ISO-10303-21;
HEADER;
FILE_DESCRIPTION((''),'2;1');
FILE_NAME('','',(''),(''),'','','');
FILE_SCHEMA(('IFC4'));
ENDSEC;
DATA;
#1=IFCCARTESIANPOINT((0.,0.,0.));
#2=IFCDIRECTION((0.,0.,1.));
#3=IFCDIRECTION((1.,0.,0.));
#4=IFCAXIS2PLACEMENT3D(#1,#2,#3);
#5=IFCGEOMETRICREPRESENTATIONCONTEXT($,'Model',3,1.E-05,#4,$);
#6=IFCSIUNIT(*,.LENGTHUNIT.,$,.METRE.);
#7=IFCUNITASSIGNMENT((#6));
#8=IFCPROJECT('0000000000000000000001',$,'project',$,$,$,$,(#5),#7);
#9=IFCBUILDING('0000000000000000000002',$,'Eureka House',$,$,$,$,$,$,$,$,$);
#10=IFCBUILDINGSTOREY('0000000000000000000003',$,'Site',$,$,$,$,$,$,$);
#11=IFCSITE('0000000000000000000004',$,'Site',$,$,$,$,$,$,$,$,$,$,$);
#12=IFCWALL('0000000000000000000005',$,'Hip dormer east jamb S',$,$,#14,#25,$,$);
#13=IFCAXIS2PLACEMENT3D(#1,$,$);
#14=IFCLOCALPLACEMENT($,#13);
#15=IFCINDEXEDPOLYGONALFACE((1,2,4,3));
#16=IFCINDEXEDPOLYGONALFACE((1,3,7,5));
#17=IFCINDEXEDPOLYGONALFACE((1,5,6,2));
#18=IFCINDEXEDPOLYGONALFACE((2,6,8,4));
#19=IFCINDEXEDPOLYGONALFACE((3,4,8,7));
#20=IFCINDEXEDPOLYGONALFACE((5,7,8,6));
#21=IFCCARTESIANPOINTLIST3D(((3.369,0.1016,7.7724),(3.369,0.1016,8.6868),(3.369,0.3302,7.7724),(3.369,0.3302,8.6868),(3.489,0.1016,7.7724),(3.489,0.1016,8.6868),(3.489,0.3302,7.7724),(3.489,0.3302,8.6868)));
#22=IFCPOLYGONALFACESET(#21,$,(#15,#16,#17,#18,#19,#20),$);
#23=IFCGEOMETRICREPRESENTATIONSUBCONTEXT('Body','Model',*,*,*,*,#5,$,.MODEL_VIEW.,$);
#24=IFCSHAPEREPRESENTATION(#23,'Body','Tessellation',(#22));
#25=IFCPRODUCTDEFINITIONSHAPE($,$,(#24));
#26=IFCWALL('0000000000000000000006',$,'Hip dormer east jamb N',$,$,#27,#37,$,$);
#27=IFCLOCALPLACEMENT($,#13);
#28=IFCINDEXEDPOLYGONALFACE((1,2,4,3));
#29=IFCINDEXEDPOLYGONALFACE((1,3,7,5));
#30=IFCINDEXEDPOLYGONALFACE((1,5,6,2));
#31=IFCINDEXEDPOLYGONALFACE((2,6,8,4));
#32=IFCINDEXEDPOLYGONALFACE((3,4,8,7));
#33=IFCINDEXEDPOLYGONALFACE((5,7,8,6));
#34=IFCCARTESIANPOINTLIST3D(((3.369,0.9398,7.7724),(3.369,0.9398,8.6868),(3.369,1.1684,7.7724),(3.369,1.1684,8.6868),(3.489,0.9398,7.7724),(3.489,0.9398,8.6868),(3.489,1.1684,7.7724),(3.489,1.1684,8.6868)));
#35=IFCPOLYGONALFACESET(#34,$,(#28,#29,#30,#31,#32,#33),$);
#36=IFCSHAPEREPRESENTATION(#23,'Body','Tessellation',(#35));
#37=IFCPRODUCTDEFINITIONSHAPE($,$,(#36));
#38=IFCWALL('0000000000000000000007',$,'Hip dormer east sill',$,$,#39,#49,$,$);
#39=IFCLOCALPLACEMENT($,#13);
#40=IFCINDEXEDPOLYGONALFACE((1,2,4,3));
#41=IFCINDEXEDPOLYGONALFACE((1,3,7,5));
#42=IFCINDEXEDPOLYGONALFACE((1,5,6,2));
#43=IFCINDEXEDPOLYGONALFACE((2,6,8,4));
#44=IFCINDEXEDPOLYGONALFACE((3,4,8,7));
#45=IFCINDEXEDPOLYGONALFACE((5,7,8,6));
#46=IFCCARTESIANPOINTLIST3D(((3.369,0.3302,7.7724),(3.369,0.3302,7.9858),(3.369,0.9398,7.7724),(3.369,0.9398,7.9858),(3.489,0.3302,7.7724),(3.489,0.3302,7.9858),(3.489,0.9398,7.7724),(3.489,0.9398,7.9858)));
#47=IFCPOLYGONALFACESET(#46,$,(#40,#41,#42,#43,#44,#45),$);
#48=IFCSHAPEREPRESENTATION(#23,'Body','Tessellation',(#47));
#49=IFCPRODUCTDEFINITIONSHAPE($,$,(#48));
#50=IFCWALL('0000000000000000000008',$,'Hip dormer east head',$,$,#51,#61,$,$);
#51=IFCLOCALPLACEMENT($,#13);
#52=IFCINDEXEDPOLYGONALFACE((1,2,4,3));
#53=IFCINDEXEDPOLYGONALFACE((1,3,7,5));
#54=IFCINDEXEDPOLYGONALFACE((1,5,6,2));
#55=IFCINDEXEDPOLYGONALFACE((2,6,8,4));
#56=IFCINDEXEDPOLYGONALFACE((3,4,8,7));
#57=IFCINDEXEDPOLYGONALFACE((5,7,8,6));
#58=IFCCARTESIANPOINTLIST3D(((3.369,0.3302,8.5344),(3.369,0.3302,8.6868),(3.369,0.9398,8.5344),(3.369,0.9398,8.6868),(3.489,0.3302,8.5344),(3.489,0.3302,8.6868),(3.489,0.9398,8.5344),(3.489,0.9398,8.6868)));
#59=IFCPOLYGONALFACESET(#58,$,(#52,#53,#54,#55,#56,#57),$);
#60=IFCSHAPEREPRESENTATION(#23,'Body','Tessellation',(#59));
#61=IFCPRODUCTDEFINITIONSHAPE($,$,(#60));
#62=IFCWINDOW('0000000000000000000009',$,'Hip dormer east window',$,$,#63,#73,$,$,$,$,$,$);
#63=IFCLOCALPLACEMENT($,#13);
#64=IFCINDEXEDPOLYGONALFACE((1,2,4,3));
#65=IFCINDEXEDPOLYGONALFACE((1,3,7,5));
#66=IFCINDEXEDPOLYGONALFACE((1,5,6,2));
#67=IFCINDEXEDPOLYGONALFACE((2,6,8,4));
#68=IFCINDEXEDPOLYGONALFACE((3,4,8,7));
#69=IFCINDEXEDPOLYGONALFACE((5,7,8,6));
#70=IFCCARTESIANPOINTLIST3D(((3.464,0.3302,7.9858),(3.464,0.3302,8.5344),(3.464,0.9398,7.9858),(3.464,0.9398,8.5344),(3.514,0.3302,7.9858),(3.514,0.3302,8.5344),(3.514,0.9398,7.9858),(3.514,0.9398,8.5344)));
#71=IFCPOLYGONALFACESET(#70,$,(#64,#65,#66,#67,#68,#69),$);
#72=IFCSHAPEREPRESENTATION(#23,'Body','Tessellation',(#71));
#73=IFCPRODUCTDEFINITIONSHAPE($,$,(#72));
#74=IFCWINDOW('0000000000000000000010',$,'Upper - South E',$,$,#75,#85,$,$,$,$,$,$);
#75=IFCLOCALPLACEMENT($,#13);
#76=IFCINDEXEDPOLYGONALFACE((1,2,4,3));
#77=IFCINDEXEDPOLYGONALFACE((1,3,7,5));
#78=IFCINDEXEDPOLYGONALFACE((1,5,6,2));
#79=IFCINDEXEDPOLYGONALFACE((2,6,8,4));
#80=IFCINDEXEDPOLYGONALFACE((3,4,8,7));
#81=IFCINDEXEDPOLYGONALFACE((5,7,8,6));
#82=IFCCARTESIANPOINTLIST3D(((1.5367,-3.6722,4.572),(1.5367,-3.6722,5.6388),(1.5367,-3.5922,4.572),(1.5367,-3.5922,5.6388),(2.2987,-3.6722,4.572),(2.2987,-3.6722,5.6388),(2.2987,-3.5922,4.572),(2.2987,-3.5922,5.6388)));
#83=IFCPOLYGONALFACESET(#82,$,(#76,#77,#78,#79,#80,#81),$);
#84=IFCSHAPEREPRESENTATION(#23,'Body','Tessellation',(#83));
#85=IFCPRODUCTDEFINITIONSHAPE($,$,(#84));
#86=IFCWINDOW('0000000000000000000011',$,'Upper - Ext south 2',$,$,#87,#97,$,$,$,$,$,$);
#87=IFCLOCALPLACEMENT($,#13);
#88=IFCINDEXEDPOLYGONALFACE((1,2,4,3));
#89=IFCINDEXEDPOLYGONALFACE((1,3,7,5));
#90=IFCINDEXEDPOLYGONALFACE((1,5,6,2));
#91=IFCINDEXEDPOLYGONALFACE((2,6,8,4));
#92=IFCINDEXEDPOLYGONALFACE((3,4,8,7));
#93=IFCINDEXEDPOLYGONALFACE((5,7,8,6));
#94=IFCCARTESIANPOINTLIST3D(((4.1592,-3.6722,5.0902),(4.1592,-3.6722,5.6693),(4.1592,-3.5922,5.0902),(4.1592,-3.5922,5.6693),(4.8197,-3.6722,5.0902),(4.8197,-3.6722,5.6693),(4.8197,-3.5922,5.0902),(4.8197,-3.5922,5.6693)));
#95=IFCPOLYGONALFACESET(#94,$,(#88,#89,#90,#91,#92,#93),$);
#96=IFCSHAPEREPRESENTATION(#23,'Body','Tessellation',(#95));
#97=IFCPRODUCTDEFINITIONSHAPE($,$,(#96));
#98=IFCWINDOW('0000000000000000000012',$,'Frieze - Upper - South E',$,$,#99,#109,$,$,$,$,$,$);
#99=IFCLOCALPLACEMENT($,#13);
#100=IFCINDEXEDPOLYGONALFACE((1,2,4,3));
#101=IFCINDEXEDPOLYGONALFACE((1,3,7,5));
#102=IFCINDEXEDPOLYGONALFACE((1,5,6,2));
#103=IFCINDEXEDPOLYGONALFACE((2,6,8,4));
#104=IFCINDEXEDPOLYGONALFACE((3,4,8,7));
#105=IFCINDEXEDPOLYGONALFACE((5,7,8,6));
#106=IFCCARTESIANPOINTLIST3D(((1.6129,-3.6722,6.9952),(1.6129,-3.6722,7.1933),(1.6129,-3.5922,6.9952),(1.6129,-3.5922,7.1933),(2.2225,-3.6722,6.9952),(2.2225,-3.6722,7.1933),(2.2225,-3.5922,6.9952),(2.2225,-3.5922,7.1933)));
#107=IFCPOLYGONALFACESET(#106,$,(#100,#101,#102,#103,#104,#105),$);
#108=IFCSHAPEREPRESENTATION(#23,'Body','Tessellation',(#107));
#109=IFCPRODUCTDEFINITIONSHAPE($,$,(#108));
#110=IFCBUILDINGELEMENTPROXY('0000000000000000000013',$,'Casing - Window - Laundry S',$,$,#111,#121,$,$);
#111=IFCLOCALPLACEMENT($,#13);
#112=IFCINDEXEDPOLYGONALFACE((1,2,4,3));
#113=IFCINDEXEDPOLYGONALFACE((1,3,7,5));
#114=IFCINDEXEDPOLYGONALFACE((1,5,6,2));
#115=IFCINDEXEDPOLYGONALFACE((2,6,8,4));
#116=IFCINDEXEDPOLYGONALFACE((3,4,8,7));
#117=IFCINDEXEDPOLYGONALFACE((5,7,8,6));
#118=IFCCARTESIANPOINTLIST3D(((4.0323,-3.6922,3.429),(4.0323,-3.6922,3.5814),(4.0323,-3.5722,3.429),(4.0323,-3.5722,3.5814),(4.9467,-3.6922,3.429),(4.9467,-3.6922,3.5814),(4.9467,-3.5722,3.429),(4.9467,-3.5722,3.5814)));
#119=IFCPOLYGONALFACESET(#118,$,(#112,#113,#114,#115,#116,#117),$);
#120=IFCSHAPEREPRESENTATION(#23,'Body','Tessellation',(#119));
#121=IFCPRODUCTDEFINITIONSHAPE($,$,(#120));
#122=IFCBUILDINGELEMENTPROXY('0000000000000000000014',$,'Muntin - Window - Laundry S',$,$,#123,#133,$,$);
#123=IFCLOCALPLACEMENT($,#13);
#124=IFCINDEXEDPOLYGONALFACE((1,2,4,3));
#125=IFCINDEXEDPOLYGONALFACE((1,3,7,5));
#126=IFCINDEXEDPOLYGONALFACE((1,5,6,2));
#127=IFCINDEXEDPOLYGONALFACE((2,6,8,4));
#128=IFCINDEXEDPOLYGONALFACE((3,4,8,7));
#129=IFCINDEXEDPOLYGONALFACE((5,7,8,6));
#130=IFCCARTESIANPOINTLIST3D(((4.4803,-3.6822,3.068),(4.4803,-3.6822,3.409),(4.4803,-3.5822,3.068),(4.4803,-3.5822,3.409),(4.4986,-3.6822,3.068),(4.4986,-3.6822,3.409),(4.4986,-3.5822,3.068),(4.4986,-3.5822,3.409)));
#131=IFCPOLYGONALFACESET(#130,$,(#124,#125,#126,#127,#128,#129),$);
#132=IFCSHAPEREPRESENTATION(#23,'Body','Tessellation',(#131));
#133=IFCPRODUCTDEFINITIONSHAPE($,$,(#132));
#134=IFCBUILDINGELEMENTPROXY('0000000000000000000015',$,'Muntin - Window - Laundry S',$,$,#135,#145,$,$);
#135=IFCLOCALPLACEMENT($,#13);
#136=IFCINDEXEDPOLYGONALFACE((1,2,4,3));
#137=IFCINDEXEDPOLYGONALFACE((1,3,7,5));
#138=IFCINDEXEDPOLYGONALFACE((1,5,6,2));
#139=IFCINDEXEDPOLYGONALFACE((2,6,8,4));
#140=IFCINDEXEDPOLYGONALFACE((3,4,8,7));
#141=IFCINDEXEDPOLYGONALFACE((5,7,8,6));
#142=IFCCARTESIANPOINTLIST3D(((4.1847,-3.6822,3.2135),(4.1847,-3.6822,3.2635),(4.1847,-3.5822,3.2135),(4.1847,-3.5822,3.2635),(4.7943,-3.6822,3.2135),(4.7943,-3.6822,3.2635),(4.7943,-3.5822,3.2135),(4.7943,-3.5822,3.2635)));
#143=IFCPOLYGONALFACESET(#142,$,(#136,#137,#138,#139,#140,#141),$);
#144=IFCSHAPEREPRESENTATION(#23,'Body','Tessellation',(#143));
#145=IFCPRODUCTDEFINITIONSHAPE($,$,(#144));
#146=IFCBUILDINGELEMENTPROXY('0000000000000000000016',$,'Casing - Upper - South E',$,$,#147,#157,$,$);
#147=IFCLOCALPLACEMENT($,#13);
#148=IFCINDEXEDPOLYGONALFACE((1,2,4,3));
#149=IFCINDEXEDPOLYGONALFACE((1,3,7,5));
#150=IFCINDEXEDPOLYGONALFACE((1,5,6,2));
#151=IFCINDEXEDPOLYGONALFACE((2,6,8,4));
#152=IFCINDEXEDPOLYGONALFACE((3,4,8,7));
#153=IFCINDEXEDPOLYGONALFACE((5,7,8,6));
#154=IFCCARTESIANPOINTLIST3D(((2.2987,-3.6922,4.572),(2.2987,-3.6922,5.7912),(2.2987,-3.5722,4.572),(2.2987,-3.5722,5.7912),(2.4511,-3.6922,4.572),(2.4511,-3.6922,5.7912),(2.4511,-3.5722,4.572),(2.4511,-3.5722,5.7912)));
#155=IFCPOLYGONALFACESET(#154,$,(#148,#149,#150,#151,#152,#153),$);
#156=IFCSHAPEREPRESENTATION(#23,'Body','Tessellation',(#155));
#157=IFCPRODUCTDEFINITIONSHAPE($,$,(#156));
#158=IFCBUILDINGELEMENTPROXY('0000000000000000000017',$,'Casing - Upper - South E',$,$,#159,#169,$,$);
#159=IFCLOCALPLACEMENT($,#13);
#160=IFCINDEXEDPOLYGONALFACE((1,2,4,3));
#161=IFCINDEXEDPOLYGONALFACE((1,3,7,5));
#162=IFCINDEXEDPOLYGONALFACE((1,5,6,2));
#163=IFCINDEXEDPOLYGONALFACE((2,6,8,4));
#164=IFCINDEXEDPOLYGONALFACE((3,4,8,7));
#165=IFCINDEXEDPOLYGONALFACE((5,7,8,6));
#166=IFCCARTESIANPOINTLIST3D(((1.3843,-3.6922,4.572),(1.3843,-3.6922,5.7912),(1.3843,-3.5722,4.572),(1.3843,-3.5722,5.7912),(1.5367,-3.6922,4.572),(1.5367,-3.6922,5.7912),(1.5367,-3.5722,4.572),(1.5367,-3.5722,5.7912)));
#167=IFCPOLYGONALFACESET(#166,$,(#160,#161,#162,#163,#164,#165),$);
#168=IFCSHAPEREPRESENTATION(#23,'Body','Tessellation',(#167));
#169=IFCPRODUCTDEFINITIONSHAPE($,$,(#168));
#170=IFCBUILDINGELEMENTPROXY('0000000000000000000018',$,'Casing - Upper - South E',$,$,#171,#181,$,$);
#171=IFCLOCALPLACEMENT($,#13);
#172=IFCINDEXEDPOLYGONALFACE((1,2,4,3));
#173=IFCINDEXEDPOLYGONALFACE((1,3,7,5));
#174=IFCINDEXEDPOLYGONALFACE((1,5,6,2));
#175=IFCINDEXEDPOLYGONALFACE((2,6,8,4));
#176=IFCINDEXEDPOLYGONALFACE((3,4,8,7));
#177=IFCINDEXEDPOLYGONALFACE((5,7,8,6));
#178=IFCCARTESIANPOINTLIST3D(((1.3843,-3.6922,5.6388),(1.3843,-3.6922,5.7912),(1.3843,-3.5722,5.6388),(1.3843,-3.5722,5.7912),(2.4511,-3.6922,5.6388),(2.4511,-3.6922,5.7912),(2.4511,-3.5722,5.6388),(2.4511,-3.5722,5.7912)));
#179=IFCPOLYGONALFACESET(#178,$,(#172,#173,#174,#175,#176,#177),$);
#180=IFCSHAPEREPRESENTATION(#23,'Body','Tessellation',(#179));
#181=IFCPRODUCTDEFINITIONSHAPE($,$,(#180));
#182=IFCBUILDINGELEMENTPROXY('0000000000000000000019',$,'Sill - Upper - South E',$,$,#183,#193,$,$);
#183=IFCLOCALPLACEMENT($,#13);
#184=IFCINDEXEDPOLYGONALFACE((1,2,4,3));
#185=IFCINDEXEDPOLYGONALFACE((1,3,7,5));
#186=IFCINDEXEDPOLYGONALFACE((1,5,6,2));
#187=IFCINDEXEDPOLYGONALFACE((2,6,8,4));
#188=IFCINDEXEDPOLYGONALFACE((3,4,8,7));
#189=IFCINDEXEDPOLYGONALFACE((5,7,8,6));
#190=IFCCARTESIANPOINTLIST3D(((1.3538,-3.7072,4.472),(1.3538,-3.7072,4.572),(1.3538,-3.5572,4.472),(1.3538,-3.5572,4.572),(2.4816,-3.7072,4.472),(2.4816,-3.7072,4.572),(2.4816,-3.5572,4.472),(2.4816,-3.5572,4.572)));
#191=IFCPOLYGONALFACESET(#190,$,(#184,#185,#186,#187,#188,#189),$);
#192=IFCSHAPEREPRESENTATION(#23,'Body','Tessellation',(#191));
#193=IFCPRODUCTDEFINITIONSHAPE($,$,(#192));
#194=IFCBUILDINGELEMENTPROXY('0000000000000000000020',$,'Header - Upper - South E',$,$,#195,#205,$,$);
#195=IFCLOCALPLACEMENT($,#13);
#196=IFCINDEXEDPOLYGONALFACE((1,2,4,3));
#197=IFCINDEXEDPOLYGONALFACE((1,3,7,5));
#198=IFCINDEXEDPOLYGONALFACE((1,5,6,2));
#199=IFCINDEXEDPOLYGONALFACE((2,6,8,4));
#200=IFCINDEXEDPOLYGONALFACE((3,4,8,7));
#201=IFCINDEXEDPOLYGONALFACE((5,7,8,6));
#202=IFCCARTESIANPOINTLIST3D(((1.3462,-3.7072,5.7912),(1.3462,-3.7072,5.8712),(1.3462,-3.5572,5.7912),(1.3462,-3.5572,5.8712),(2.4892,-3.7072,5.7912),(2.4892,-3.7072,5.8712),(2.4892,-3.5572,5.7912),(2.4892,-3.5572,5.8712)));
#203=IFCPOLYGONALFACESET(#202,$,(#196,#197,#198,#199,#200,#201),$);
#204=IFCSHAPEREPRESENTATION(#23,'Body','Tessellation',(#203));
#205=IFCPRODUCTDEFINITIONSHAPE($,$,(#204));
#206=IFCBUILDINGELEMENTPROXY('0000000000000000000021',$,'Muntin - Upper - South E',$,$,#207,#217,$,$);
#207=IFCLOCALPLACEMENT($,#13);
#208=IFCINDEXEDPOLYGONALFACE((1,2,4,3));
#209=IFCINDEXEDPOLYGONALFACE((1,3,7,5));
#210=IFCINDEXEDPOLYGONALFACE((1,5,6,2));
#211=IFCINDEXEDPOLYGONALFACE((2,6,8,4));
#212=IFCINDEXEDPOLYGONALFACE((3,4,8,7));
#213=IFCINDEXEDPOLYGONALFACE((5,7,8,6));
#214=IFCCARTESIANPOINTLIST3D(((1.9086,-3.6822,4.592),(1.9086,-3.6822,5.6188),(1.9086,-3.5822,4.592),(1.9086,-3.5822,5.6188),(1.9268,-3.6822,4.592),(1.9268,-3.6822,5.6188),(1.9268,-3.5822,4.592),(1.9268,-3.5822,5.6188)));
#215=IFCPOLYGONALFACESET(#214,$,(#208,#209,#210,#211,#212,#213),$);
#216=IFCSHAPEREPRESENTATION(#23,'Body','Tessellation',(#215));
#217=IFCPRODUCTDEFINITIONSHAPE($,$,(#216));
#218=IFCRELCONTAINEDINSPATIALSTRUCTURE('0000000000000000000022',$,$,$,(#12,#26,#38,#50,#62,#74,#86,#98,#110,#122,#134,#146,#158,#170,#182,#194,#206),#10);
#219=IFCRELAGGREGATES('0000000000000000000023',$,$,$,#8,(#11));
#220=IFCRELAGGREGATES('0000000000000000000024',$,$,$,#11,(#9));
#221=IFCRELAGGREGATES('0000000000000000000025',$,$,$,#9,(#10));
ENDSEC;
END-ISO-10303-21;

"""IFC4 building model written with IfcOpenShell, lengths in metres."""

from ifc_helpers import new_model, si_unit, frame, origin, origin_with_axes, origin_2d, place, context, subcontext, project, spatial, rectangle, extrude, element, save


model = new_model("IFC4")

# Units and contexts
model_context = context("Model", 3, precision=1e-05, world=origin_with_axes())
body_context = subcontext(model_context, "Body", "Model", "MODEL_VIEW")
ifc_project = project(units=[si_unit("LENGTHUNIT", "METRE")], contexts=[model_context])

# Site, building, storey
site = spatial("IfcSite", under=ifc_project, Name="Site")
building = spatial("IfcBuilding", under=site, Name="Eureka House")
storey = spatial("IfcBuildingStorey", under=building, Name="Site")

# Walls
wall_1_placement = place(None, frame((3.429, 0.2159, 7.7724), z_axis=(0.0, 0.0, 1.0), x_axis=(1.0, 0.0, 0.0)))
element("IfcWall", 1, at=wall_1_placement, inside=storey, Name="Hip dormer east jamb S", context=body_context, shape_type="SweptSolid", body=[
    extrude(rectangle(XDim=0.12, YDim=0.2286, at=origin_2d()), origin(), (0.0, 0.0, 1.0), 0.9144),
])
wall_2_placement = place(None, frame((3.429, 1.0541, 7.7724), z_axis=(0.0, 0.0, 1.0), x_axis=(1.0, 0.0, 0.0)))
element("IfcWall", 2, at=wall_2_placement, inside=storey, Name="Hip dormer east jamb N", context=body_context, shape_type="SweptSolid", body=[
    extrude(rectangle(XDim=0.12, YDim=0.2286, at=origin_2d()), origin(), (0.0, 0.0, 1.0), 0.9144),
])
wall_3_placement = place(None, frame((3.429, 0.635, 7.7724), z_axis=(0.0, 0.0, 1.0), x_axis=(1.0, 0.0, 0.0)))
element("IfcWall", 3, at=wall_3_placement, inside=storey, Name="Hip dormer east sill", context=body_context, shape_type="SweptSolid", body=[
    extrude(rectangle(XDim=0.12, YDim=0.6096, at=origin_2d()), origin(), (0.0, 0.0, 1.0), 0.2134),
])
wall_4_placement = place(None, frame((3.429, 0.635, 8.5344), z_axis=(0.0, 0.0, 1.0), x_axis=(1.0, 0.0, 0.0)))
element("IfcWall", 4, at=wall_4_placement, inside=storey, Name="Hip dormer east head", context=body_context, shape_type="SweptSolid", body=[
    extrude(rectangle(XDim=0.12, YDim=0.6096, at=origin_2d()), origin(), (0.0, 0.0, 1.0), 0.1524),
])

# Windows
window_1_placement = place(None, frame((3.489, 0.635, 7.9858), z_axis=(0.0, 0.0, 1.0), x_axis=(1.0, 0.0, 0.0)))
element("IfcWindow", 5, at=window_1_placement, inside=storey, Name="Hip dormer east window", context=body_context, shape_type="SweptSolid", body=[
    extrude(rectangle(XDim=0.05, YDim=0.6096, at=origin_2d()), origin(), (0.0, 0.0, 1.0), 0.5486),
])
window_2_placement = place(None, frame((1.9177, -3.6322, 4.572), z_axis=(0.0, 0.0, 1.0), x_axis=(1.0, 0.0, 0.0)))
element("IfcWindow", 6, at=window_2_placement, inside=storey, Name="Upper - South E", context=body_context, shape_type="SweptSolid", body=[
    extrude(rectangle(XDim=0.762, YDim=0.08, at=origin_2d()), origin(), (0.0, 0.0, 1.0), 1.0668),
])
window_3_placement = place(None, frame((4.4894, -3.6322, 5.0902), z_axis=(0.0, 0.0, 1.0), x_axis=(1.0, 0.0, 0.0)))
element("IfcWindow", 7, at=window_3_placement, inside=storey, Name="Upper - Ext south 2", context=body_context, shape_type="SweptSolid", body=[
    extrude(rectangle(XDim=0.6605, YDim=0.08, at=origin_2d()), origin(), (0.0, 0.0, 1.0), 0.5791),
])
window_4_placement = place(None, frame((1.9177, -3.6322, 6.9952), z_axis=(0.0, 0.0, 1.0), x_axis=(1.0, 0.0, 0.0)))
element("IfcWindow", 8, at=window_4_placement, inside=storey, Name="Frieze - Upper - South E", context=body_context, shape_type="SweptSolid", body=[
    extrude(rectangle(XDim=0.6096, YDim=0.08, at=origin_2d()), origin(), (0.0, 0.0, 1.0), 0.1981),
])

# Building element proxies
proxy_1_placement = place(None, frame((4.4895, -3.6322, 3.429), z_axis=(0.0, 0.0, 1.0), x_axis=(1.0, 0.0, 0.0)))
element("IfcBuildingElementProxy", 9, at=proxy_1_placement, inside=storey, Name="Casing - Window - Laundry S", context=body_context, shape_type="SweptSolid", body=[
    extrude(rectangle(XDim=0.9144, YDim=0.12, at=origin_2d()), origin(), (0.0, 0.0, 1.0), 0.1524),
])
proxy_2_placement = place(None, frame((4.4895, -3.6322, 3.068), z_axis=(0.0, 0.0, 1.0), x_axis=(1.0, 0.0, 0.0)))
element("IfcBuildingElementProxy", 10, at=proxy_2_placement, inside=storey, Name="Muntin - Window - Laundry S", context=body_context, shape_type="SweptSolid", body=[
    extrude(rectangle(XDim=0.0183, YDim=0.1, at=origin_2d()), origin(), (0.0, 0.0, 1.0), 0.341),
])
proxy_3_placement = place(None, frame((4.4895, -3.6322, 3.2135), z_axis=(0.0, 0.0, 1.0), x_axis=(1.0, 0.0, 0.0)))
element("IfcBuildingElementProxy", 11, at=proxy_3_placement, inside=storey, Name="Muntin - Window - Laundry S", context=body_context, shape_type="SweptSolid", body=[
    extrude(rectangle(XDim=0.6096, YDim=0.1, at=origin_2d()), origin(), (0.0, 0.0, 1.0), 0.05),
])
for number, where, z_axis, x_axis, name in (
    (12, (2.3749, -3.6322, 4.572), (0.0, 0.0, 1.0), (1.0, 0.0, 0.0), "Casing - Upper - South E"),
    (13, (1.4605, -3.6322, 4.572), (0.0, 0.0, 1.0), (1.0, 0.0, 0.0), "Casing - Upper - South E"),
):
    element("IfcBuildingElementProxy", number, at=place(None, frame(where, z_axis=z_axis, x_axis=x_axis)), inside=storey, Name=name, context=body_context, shape_type="SweptSolid", body=[
        extrude(rectangle(XDim=0.1524, YDim=0.12, at=origin_2d()), origin(), (0.0, 0.0, 1.0), 1.2192),
    ])
proxy_4_placement = place(None, frame((1.9177, -3.6322, 5.6388), z_axis=(0.0, 0.0, 1.0), x_axis=(1.0, 0.0, 0.0)))
element("IfcBuildingElementProxy", 14, at=proxy_4_placement, inside=storey, Name="Casing - Upper - South E", context=body_context, shape_type="SweptSolid", body=[
    extrude(rectangle(XDim=1.0668, YDim=0.12, at=origin_2d()), origin(), (0.0, 0.0, 1.0), 0.1524),
])
proxy_5_placement = place(None, frame((1.9177, -3.6322, 4.472), z_axis=(0.0, 0.0, 1.0), x_axis=(1.0, 0.0, 0.0)))
element("IfcBuildingElementProxy", 15, at=proxy_5_placement, inside=storey, Name="Sill - Upper - South E", context=body_context, shape_type="SweptSolid", body=[
    extrude(rectangle(XDim=1.1278, YDim=0.15, at=origin_2d()), origin(), (0.0, 0.0, 1.0), 0.1),
])
proxy_6_placement = place(None, frame((1.9177, -3.6322, 5.7912), z_axis=(0.0, 0.0, 1.0), x_axis=(1.0, 0.0, 0.0)))
element("IfcBuildingElementProxy", 16, at=proxy_6_placement, inside=storey, Name="Header - Upper - South E", context=body_context, shape_type="SweptSolid", body=[
    extrude(rectangle(XDim=1.143, YDim=0.15, at=origin_2d()), origin(), (0.0, 0.0, 1.0), 0.08),
])
proxy_7_placement = place(None, frame((1.9177, -3.6322, 4.592), z_axis=(0.0, 0.0, 1.0), x_axis=(1.0, 0.0, 0.0)))
element("IfcBuildingElementProxy", 17, at=proxy_7_placement, inside=storey, Name="Muntin - Upper - South E", context=body_context, shape_type="SweptSolid", body=[
    extrude(rectangle(XDim=0.0183, YDim=0.1, at=origin_2d()), origin(), (0.0, 0.0, 1.0), 1.0268),
])

save(model, "model.ifc")
